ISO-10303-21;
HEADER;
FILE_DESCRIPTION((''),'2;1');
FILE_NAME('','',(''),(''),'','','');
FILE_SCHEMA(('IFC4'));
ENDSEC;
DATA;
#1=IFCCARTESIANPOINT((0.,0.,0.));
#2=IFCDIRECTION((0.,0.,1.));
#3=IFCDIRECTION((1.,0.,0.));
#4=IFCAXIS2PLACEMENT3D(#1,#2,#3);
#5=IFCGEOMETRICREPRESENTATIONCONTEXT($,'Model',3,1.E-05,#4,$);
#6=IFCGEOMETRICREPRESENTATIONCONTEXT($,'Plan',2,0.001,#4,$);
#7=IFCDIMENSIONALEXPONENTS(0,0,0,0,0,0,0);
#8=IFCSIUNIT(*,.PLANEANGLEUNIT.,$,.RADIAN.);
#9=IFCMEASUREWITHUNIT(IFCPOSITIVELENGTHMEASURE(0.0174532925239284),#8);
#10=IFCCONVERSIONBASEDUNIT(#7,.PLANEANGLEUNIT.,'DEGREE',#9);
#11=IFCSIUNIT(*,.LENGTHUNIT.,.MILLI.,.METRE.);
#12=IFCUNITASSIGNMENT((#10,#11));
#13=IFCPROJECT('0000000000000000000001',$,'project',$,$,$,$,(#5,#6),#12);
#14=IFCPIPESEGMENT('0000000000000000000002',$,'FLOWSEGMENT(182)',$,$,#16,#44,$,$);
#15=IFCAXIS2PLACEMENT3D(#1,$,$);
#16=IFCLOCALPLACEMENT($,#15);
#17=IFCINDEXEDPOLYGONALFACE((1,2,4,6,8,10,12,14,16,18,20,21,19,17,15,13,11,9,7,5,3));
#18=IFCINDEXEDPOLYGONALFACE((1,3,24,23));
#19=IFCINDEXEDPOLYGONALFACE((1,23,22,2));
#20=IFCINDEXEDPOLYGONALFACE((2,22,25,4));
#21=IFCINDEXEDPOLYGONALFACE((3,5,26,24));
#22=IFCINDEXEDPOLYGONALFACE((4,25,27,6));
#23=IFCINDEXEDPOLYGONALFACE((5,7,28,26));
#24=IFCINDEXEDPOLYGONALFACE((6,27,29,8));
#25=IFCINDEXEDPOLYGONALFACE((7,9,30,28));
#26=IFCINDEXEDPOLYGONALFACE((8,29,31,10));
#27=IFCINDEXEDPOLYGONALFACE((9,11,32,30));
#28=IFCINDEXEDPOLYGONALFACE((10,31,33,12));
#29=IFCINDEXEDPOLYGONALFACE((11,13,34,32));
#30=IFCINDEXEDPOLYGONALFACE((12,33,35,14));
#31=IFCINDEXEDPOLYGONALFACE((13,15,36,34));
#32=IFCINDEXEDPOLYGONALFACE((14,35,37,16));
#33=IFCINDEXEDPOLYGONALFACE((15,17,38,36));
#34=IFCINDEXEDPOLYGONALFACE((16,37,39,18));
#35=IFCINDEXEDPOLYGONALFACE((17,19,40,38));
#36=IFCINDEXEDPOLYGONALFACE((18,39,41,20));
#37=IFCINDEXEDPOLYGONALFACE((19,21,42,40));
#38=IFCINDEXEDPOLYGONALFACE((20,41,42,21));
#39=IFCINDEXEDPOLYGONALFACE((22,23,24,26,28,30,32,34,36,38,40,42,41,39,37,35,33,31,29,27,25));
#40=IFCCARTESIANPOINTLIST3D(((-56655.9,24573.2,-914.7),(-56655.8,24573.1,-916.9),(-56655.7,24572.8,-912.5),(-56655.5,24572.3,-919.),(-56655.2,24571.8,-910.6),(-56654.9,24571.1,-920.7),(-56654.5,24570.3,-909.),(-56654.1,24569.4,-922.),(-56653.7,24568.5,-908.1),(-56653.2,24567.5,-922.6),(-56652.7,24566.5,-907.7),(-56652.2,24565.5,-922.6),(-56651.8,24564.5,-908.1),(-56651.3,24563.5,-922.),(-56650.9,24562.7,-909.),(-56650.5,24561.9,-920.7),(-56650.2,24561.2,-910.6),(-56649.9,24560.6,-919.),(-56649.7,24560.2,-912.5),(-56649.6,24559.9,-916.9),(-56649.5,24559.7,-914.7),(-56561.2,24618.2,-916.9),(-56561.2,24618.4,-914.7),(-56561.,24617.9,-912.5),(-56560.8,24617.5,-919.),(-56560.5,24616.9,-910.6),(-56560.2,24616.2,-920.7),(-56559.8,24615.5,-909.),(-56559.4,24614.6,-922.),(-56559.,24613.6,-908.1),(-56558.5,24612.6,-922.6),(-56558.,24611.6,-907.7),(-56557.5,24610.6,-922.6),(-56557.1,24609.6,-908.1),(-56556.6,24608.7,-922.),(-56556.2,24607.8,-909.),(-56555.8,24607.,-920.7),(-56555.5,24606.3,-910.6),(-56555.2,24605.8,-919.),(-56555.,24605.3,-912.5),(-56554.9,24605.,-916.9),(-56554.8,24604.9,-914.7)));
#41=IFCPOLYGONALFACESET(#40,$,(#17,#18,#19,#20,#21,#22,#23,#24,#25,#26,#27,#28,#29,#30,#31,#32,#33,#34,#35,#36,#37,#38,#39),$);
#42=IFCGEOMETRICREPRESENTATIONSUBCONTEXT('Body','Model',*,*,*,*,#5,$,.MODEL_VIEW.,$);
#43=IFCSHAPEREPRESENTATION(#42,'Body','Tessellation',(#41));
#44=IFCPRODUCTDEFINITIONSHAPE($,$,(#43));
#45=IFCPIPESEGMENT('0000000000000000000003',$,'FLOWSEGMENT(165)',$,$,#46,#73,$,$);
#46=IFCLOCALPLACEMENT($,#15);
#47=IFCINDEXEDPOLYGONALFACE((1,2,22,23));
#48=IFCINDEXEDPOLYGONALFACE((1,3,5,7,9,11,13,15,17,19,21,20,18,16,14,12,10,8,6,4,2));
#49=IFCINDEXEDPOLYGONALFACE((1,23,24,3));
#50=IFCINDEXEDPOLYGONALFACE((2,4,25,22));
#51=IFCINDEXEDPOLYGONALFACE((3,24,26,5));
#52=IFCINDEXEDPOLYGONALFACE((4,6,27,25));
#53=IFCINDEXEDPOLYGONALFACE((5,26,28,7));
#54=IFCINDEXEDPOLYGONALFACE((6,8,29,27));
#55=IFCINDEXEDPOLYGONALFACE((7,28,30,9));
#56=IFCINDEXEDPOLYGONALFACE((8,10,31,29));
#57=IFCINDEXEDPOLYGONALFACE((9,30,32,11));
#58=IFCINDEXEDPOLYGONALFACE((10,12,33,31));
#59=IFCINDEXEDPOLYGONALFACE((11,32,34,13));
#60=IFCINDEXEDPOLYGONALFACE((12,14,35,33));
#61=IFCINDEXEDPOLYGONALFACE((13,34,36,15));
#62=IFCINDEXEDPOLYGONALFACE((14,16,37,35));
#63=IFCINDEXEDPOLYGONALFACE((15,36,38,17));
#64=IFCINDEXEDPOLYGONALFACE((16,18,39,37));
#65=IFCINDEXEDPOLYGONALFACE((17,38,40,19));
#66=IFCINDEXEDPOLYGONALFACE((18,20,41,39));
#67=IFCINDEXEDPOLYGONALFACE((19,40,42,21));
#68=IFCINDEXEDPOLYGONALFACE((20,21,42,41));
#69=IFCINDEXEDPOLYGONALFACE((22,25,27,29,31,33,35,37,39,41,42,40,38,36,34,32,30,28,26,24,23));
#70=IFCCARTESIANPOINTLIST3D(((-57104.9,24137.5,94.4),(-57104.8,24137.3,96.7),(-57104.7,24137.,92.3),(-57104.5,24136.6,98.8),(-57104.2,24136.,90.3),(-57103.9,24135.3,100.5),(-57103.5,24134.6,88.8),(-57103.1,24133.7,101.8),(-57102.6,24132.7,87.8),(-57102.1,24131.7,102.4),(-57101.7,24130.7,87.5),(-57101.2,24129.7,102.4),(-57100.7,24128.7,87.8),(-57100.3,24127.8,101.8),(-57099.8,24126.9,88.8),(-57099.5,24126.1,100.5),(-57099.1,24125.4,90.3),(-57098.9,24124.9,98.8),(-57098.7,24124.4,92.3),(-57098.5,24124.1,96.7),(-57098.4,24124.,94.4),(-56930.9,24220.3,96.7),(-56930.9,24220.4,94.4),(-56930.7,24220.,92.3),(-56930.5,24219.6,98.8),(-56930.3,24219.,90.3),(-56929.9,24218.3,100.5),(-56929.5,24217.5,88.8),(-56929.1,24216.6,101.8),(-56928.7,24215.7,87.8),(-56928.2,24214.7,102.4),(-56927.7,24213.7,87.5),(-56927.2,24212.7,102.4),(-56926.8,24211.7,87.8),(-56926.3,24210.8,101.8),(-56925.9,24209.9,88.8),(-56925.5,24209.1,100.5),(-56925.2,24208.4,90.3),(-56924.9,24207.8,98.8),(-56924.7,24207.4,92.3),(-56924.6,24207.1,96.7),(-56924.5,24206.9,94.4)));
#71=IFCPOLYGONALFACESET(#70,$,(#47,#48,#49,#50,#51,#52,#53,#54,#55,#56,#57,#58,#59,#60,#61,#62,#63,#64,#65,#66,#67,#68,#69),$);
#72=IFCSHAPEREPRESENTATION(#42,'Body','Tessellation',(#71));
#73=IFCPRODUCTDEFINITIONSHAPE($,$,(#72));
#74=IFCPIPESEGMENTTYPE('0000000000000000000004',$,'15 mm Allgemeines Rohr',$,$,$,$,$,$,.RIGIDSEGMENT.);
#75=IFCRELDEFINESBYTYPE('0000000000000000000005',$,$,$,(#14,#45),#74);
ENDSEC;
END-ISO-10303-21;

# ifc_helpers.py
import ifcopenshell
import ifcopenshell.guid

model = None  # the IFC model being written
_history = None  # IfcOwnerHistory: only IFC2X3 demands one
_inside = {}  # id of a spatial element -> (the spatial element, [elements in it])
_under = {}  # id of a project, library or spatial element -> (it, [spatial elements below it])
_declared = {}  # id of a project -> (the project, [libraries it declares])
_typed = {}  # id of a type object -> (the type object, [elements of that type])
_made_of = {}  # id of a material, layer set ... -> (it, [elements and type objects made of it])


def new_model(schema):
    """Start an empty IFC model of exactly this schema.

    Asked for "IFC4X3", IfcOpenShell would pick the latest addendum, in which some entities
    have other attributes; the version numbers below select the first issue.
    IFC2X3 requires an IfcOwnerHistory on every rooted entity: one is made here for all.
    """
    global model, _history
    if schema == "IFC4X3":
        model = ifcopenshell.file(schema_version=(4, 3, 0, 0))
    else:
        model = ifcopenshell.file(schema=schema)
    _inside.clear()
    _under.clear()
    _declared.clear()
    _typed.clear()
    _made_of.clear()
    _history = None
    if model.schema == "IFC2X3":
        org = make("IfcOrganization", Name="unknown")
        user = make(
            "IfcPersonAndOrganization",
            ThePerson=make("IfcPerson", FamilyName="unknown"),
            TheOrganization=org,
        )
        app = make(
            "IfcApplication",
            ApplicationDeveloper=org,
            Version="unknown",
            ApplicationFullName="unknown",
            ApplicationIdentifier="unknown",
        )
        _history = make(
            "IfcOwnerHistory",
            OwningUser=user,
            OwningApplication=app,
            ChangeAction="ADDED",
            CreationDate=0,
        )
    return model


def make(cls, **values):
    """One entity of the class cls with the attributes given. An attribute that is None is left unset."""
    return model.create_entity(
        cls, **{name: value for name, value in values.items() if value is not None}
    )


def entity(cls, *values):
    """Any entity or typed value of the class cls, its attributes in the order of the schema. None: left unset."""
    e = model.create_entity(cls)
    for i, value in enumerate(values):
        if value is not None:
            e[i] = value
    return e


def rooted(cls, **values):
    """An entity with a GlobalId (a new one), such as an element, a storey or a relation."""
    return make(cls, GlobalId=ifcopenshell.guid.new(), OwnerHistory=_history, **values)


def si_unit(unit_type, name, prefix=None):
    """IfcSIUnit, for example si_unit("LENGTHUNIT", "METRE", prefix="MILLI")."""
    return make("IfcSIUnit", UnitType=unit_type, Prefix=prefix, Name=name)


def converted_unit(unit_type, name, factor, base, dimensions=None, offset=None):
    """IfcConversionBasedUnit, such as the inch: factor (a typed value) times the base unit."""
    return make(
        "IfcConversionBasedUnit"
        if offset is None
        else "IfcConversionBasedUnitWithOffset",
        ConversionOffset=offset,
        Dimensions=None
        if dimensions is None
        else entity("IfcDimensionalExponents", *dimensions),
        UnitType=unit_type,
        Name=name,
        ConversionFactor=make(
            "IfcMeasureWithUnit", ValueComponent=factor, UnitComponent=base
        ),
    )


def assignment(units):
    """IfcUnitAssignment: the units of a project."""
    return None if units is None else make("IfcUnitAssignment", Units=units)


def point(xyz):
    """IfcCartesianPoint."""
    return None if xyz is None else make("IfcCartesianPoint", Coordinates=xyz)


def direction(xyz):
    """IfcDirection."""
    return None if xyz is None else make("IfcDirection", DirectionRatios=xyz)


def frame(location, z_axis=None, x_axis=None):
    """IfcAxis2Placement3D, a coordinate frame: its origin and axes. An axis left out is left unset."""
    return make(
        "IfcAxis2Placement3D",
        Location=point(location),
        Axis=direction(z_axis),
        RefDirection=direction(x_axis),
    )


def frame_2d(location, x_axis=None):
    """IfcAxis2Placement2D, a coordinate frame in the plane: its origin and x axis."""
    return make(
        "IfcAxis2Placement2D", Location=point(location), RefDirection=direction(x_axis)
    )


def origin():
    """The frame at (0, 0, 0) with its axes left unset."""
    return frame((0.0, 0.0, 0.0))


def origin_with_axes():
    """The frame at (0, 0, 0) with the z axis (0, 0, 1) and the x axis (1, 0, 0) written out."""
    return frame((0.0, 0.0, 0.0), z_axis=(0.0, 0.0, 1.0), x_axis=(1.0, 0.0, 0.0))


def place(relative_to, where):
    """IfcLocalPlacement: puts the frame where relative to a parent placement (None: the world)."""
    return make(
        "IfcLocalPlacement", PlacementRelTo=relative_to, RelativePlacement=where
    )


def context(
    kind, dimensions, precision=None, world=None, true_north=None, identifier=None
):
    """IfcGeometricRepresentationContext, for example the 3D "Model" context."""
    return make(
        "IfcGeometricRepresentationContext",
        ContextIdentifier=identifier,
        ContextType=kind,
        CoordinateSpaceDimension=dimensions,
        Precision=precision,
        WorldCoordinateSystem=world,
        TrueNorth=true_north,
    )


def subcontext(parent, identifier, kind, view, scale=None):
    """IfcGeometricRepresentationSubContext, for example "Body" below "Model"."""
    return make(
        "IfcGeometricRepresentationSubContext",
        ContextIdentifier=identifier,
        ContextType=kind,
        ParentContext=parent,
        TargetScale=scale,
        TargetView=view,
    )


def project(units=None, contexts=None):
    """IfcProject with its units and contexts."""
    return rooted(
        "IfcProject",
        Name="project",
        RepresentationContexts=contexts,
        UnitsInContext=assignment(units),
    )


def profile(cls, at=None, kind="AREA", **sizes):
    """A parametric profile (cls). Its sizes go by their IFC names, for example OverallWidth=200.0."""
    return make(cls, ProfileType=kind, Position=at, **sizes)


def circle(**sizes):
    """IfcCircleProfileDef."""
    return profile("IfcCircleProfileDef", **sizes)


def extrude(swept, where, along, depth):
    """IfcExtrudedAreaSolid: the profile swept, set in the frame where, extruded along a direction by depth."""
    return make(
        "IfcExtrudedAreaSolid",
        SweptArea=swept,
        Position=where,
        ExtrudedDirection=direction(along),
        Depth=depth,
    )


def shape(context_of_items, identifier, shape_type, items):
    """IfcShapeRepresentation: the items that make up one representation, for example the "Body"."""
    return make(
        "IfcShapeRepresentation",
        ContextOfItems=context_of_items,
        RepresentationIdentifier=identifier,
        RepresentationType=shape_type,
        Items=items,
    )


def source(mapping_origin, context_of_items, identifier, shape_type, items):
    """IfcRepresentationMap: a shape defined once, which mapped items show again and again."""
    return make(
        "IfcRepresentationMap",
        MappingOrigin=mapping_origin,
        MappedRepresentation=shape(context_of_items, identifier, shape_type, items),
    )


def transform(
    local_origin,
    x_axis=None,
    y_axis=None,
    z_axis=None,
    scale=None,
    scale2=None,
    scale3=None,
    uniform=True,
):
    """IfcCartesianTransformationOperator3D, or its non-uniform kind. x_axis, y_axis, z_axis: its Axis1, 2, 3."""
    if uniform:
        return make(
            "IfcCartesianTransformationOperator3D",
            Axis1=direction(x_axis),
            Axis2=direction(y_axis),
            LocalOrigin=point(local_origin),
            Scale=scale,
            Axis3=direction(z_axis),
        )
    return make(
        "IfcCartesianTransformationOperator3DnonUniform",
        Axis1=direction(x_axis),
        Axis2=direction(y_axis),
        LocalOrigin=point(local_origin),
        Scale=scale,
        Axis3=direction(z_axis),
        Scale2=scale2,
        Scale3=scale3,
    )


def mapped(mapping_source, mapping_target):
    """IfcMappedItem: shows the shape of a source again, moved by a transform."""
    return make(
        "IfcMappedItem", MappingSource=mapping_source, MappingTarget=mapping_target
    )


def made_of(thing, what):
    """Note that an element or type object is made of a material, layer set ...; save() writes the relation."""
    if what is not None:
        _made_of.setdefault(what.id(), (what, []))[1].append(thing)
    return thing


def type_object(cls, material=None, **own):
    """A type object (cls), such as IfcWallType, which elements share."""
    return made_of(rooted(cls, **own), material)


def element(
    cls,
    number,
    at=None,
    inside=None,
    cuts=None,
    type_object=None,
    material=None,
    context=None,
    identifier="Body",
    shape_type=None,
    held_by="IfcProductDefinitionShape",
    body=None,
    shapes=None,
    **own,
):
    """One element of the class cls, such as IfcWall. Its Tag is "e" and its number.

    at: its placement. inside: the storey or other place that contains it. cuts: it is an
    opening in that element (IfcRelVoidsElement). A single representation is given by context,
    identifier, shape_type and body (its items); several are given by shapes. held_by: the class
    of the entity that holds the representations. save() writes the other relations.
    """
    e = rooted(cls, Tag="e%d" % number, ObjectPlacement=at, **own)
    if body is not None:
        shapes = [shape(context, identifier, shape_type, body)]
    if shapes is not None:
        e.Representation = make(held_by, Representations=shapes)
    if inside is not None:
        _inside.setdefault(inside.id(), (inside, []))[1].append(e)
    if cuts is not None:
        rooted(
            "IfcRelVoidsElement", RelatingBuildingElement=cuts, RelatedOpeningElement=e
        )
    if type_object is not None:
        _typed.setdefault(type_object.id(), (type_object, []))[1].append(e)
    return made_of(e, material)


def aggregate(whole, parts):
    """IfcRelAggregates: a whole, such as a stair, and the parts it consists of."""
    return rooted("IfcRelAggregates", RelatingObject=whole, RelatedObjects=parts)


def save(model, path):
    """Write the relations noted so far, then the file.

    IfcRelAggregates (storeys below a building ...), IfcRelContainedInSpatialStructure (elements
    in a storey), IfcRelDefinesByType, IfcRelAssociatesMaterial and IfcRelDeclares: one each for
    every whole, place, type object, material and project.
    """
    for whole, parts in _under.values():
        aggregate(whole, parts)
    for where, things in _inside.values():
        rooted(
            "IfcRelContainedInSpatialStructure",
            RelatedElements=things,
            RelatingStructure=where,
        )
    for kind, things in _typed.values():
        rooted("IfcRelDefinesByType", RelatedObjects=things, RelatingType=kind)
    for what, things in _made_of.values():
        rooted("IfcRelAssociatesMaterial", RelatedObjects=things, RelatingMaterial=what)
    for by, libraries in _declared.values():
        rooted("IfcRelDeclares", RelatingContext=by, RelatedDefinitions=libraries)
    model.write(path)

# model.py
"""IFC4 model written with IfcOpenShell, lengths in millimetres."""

from ifc_helpers import new_model, entity, si_unit, converted_unit, frame, frame_2d, origin, origin_with_axes, place, context, subcontext, project, circle, extrude, source, transform, mapped, type_object, element, save


model = new_model("IFC4")

# Units and contexts
model_context = context("Model", 3, precision=1e-05, world=origin_with_axes())
plan_context = context("Plan", 2, precision=0.001, world=origin_with_axes())
body_context = subcontext(model_context, "Body", "Model", "MODEL_VIEW")
ifc_project = project(units=[converted_unit("PLANEANGLEUNIT", "DEGREE", entity("IfcPositiveLengthMeasure", 0.0174532925239284), si_unit("PLANEANGLEUNIT", "RADIAN"), dimensions=[0, 0, 0, 0, 0, 0, 0]), si_unit("LENGTHUNIT", "METRE", prefix="MILLI")], contexts=[model_context, plan_context])

# Pipe segments
pipe_segment_type = type_object("IfcPipeSegmentType", Name="15 mm Allgemeines Rohr", PredefinedType="RIGIDSEGMENT")
shared_shape = source(origin(), body_context, "Body", "SweptSolid", [
    extrude(circle(Radius=7.5, at=frame_2d((7.5, 7.5), x_axis=(1.0, 0.0))), frame((0.0, -7.5, -7.5), z_axis=(1.0, 0.0, 0.0), x_axis=(0.0, 1.0, 0.0)), (0.0, 0.0, 1.0), 1.0),
])
placement_1 = place(None, origin_with_axes())
placement_2 = place(placement_1, origin_with_axes())
placement_3 = place(placement_2, frame((0.0, 0.0, -3400.0), z_axis=(0.0, 0.0, 1.0), x_axis=(1.0, 0.0, 0.0)))
pipe_segment_1_placement = place(placement_3, frame((-56558.0, 24611.6, 2484.8), z_axis=(-0.430461, 0.902609, 0.0), x_axis=(-0.902609, -0.430461, 0.0)))
element("IfcPipeSegment", 1, at=pipe_segment_1_placement, type_object=pipe_segment_type, Name="FLOWSEGMENT(182)", context=body_context, shape_type="MappedRepresentation", body=[
    mapped(shared_shape, transform((0.0, 0.0, 0.0), x_axis=(1.0, 0.0, 0.0), y_axis=(0.0, 1.0, 0.0), z_axis=(0.0, 0.0, 1.0), scale=104.898581, scale2=1.0, scale3=1.0, uniform=False)),
])
pipe_segment_2_placement = place(placement_3, frame((-57101.7, 24130.7, 3495.0), z_axis=(-0.430461, 0.902609, 0.0), x_axis=(0.902609, 0.430461, 0.0)))
element("IfcPipeSegment", 2, at=pipe_segment_2_placement, type_object=pipe_segment_type, Name="FLOWSEGMENT(165)", context=body_context, shape_type="MappedRepresentation", body=[
    mapped(shared_shape, transform((0.0, 0.0, 0.0), x_axis=(1.0, 0.0, 0.0), y_axis=(0.0, 1.0, 0.0), z_axis=(0.0, 0.0, 1.0), scale=192.697716, scale2=1.0, scale3=1.0, uniform=False)),
])

save(model, "model.ifc")
